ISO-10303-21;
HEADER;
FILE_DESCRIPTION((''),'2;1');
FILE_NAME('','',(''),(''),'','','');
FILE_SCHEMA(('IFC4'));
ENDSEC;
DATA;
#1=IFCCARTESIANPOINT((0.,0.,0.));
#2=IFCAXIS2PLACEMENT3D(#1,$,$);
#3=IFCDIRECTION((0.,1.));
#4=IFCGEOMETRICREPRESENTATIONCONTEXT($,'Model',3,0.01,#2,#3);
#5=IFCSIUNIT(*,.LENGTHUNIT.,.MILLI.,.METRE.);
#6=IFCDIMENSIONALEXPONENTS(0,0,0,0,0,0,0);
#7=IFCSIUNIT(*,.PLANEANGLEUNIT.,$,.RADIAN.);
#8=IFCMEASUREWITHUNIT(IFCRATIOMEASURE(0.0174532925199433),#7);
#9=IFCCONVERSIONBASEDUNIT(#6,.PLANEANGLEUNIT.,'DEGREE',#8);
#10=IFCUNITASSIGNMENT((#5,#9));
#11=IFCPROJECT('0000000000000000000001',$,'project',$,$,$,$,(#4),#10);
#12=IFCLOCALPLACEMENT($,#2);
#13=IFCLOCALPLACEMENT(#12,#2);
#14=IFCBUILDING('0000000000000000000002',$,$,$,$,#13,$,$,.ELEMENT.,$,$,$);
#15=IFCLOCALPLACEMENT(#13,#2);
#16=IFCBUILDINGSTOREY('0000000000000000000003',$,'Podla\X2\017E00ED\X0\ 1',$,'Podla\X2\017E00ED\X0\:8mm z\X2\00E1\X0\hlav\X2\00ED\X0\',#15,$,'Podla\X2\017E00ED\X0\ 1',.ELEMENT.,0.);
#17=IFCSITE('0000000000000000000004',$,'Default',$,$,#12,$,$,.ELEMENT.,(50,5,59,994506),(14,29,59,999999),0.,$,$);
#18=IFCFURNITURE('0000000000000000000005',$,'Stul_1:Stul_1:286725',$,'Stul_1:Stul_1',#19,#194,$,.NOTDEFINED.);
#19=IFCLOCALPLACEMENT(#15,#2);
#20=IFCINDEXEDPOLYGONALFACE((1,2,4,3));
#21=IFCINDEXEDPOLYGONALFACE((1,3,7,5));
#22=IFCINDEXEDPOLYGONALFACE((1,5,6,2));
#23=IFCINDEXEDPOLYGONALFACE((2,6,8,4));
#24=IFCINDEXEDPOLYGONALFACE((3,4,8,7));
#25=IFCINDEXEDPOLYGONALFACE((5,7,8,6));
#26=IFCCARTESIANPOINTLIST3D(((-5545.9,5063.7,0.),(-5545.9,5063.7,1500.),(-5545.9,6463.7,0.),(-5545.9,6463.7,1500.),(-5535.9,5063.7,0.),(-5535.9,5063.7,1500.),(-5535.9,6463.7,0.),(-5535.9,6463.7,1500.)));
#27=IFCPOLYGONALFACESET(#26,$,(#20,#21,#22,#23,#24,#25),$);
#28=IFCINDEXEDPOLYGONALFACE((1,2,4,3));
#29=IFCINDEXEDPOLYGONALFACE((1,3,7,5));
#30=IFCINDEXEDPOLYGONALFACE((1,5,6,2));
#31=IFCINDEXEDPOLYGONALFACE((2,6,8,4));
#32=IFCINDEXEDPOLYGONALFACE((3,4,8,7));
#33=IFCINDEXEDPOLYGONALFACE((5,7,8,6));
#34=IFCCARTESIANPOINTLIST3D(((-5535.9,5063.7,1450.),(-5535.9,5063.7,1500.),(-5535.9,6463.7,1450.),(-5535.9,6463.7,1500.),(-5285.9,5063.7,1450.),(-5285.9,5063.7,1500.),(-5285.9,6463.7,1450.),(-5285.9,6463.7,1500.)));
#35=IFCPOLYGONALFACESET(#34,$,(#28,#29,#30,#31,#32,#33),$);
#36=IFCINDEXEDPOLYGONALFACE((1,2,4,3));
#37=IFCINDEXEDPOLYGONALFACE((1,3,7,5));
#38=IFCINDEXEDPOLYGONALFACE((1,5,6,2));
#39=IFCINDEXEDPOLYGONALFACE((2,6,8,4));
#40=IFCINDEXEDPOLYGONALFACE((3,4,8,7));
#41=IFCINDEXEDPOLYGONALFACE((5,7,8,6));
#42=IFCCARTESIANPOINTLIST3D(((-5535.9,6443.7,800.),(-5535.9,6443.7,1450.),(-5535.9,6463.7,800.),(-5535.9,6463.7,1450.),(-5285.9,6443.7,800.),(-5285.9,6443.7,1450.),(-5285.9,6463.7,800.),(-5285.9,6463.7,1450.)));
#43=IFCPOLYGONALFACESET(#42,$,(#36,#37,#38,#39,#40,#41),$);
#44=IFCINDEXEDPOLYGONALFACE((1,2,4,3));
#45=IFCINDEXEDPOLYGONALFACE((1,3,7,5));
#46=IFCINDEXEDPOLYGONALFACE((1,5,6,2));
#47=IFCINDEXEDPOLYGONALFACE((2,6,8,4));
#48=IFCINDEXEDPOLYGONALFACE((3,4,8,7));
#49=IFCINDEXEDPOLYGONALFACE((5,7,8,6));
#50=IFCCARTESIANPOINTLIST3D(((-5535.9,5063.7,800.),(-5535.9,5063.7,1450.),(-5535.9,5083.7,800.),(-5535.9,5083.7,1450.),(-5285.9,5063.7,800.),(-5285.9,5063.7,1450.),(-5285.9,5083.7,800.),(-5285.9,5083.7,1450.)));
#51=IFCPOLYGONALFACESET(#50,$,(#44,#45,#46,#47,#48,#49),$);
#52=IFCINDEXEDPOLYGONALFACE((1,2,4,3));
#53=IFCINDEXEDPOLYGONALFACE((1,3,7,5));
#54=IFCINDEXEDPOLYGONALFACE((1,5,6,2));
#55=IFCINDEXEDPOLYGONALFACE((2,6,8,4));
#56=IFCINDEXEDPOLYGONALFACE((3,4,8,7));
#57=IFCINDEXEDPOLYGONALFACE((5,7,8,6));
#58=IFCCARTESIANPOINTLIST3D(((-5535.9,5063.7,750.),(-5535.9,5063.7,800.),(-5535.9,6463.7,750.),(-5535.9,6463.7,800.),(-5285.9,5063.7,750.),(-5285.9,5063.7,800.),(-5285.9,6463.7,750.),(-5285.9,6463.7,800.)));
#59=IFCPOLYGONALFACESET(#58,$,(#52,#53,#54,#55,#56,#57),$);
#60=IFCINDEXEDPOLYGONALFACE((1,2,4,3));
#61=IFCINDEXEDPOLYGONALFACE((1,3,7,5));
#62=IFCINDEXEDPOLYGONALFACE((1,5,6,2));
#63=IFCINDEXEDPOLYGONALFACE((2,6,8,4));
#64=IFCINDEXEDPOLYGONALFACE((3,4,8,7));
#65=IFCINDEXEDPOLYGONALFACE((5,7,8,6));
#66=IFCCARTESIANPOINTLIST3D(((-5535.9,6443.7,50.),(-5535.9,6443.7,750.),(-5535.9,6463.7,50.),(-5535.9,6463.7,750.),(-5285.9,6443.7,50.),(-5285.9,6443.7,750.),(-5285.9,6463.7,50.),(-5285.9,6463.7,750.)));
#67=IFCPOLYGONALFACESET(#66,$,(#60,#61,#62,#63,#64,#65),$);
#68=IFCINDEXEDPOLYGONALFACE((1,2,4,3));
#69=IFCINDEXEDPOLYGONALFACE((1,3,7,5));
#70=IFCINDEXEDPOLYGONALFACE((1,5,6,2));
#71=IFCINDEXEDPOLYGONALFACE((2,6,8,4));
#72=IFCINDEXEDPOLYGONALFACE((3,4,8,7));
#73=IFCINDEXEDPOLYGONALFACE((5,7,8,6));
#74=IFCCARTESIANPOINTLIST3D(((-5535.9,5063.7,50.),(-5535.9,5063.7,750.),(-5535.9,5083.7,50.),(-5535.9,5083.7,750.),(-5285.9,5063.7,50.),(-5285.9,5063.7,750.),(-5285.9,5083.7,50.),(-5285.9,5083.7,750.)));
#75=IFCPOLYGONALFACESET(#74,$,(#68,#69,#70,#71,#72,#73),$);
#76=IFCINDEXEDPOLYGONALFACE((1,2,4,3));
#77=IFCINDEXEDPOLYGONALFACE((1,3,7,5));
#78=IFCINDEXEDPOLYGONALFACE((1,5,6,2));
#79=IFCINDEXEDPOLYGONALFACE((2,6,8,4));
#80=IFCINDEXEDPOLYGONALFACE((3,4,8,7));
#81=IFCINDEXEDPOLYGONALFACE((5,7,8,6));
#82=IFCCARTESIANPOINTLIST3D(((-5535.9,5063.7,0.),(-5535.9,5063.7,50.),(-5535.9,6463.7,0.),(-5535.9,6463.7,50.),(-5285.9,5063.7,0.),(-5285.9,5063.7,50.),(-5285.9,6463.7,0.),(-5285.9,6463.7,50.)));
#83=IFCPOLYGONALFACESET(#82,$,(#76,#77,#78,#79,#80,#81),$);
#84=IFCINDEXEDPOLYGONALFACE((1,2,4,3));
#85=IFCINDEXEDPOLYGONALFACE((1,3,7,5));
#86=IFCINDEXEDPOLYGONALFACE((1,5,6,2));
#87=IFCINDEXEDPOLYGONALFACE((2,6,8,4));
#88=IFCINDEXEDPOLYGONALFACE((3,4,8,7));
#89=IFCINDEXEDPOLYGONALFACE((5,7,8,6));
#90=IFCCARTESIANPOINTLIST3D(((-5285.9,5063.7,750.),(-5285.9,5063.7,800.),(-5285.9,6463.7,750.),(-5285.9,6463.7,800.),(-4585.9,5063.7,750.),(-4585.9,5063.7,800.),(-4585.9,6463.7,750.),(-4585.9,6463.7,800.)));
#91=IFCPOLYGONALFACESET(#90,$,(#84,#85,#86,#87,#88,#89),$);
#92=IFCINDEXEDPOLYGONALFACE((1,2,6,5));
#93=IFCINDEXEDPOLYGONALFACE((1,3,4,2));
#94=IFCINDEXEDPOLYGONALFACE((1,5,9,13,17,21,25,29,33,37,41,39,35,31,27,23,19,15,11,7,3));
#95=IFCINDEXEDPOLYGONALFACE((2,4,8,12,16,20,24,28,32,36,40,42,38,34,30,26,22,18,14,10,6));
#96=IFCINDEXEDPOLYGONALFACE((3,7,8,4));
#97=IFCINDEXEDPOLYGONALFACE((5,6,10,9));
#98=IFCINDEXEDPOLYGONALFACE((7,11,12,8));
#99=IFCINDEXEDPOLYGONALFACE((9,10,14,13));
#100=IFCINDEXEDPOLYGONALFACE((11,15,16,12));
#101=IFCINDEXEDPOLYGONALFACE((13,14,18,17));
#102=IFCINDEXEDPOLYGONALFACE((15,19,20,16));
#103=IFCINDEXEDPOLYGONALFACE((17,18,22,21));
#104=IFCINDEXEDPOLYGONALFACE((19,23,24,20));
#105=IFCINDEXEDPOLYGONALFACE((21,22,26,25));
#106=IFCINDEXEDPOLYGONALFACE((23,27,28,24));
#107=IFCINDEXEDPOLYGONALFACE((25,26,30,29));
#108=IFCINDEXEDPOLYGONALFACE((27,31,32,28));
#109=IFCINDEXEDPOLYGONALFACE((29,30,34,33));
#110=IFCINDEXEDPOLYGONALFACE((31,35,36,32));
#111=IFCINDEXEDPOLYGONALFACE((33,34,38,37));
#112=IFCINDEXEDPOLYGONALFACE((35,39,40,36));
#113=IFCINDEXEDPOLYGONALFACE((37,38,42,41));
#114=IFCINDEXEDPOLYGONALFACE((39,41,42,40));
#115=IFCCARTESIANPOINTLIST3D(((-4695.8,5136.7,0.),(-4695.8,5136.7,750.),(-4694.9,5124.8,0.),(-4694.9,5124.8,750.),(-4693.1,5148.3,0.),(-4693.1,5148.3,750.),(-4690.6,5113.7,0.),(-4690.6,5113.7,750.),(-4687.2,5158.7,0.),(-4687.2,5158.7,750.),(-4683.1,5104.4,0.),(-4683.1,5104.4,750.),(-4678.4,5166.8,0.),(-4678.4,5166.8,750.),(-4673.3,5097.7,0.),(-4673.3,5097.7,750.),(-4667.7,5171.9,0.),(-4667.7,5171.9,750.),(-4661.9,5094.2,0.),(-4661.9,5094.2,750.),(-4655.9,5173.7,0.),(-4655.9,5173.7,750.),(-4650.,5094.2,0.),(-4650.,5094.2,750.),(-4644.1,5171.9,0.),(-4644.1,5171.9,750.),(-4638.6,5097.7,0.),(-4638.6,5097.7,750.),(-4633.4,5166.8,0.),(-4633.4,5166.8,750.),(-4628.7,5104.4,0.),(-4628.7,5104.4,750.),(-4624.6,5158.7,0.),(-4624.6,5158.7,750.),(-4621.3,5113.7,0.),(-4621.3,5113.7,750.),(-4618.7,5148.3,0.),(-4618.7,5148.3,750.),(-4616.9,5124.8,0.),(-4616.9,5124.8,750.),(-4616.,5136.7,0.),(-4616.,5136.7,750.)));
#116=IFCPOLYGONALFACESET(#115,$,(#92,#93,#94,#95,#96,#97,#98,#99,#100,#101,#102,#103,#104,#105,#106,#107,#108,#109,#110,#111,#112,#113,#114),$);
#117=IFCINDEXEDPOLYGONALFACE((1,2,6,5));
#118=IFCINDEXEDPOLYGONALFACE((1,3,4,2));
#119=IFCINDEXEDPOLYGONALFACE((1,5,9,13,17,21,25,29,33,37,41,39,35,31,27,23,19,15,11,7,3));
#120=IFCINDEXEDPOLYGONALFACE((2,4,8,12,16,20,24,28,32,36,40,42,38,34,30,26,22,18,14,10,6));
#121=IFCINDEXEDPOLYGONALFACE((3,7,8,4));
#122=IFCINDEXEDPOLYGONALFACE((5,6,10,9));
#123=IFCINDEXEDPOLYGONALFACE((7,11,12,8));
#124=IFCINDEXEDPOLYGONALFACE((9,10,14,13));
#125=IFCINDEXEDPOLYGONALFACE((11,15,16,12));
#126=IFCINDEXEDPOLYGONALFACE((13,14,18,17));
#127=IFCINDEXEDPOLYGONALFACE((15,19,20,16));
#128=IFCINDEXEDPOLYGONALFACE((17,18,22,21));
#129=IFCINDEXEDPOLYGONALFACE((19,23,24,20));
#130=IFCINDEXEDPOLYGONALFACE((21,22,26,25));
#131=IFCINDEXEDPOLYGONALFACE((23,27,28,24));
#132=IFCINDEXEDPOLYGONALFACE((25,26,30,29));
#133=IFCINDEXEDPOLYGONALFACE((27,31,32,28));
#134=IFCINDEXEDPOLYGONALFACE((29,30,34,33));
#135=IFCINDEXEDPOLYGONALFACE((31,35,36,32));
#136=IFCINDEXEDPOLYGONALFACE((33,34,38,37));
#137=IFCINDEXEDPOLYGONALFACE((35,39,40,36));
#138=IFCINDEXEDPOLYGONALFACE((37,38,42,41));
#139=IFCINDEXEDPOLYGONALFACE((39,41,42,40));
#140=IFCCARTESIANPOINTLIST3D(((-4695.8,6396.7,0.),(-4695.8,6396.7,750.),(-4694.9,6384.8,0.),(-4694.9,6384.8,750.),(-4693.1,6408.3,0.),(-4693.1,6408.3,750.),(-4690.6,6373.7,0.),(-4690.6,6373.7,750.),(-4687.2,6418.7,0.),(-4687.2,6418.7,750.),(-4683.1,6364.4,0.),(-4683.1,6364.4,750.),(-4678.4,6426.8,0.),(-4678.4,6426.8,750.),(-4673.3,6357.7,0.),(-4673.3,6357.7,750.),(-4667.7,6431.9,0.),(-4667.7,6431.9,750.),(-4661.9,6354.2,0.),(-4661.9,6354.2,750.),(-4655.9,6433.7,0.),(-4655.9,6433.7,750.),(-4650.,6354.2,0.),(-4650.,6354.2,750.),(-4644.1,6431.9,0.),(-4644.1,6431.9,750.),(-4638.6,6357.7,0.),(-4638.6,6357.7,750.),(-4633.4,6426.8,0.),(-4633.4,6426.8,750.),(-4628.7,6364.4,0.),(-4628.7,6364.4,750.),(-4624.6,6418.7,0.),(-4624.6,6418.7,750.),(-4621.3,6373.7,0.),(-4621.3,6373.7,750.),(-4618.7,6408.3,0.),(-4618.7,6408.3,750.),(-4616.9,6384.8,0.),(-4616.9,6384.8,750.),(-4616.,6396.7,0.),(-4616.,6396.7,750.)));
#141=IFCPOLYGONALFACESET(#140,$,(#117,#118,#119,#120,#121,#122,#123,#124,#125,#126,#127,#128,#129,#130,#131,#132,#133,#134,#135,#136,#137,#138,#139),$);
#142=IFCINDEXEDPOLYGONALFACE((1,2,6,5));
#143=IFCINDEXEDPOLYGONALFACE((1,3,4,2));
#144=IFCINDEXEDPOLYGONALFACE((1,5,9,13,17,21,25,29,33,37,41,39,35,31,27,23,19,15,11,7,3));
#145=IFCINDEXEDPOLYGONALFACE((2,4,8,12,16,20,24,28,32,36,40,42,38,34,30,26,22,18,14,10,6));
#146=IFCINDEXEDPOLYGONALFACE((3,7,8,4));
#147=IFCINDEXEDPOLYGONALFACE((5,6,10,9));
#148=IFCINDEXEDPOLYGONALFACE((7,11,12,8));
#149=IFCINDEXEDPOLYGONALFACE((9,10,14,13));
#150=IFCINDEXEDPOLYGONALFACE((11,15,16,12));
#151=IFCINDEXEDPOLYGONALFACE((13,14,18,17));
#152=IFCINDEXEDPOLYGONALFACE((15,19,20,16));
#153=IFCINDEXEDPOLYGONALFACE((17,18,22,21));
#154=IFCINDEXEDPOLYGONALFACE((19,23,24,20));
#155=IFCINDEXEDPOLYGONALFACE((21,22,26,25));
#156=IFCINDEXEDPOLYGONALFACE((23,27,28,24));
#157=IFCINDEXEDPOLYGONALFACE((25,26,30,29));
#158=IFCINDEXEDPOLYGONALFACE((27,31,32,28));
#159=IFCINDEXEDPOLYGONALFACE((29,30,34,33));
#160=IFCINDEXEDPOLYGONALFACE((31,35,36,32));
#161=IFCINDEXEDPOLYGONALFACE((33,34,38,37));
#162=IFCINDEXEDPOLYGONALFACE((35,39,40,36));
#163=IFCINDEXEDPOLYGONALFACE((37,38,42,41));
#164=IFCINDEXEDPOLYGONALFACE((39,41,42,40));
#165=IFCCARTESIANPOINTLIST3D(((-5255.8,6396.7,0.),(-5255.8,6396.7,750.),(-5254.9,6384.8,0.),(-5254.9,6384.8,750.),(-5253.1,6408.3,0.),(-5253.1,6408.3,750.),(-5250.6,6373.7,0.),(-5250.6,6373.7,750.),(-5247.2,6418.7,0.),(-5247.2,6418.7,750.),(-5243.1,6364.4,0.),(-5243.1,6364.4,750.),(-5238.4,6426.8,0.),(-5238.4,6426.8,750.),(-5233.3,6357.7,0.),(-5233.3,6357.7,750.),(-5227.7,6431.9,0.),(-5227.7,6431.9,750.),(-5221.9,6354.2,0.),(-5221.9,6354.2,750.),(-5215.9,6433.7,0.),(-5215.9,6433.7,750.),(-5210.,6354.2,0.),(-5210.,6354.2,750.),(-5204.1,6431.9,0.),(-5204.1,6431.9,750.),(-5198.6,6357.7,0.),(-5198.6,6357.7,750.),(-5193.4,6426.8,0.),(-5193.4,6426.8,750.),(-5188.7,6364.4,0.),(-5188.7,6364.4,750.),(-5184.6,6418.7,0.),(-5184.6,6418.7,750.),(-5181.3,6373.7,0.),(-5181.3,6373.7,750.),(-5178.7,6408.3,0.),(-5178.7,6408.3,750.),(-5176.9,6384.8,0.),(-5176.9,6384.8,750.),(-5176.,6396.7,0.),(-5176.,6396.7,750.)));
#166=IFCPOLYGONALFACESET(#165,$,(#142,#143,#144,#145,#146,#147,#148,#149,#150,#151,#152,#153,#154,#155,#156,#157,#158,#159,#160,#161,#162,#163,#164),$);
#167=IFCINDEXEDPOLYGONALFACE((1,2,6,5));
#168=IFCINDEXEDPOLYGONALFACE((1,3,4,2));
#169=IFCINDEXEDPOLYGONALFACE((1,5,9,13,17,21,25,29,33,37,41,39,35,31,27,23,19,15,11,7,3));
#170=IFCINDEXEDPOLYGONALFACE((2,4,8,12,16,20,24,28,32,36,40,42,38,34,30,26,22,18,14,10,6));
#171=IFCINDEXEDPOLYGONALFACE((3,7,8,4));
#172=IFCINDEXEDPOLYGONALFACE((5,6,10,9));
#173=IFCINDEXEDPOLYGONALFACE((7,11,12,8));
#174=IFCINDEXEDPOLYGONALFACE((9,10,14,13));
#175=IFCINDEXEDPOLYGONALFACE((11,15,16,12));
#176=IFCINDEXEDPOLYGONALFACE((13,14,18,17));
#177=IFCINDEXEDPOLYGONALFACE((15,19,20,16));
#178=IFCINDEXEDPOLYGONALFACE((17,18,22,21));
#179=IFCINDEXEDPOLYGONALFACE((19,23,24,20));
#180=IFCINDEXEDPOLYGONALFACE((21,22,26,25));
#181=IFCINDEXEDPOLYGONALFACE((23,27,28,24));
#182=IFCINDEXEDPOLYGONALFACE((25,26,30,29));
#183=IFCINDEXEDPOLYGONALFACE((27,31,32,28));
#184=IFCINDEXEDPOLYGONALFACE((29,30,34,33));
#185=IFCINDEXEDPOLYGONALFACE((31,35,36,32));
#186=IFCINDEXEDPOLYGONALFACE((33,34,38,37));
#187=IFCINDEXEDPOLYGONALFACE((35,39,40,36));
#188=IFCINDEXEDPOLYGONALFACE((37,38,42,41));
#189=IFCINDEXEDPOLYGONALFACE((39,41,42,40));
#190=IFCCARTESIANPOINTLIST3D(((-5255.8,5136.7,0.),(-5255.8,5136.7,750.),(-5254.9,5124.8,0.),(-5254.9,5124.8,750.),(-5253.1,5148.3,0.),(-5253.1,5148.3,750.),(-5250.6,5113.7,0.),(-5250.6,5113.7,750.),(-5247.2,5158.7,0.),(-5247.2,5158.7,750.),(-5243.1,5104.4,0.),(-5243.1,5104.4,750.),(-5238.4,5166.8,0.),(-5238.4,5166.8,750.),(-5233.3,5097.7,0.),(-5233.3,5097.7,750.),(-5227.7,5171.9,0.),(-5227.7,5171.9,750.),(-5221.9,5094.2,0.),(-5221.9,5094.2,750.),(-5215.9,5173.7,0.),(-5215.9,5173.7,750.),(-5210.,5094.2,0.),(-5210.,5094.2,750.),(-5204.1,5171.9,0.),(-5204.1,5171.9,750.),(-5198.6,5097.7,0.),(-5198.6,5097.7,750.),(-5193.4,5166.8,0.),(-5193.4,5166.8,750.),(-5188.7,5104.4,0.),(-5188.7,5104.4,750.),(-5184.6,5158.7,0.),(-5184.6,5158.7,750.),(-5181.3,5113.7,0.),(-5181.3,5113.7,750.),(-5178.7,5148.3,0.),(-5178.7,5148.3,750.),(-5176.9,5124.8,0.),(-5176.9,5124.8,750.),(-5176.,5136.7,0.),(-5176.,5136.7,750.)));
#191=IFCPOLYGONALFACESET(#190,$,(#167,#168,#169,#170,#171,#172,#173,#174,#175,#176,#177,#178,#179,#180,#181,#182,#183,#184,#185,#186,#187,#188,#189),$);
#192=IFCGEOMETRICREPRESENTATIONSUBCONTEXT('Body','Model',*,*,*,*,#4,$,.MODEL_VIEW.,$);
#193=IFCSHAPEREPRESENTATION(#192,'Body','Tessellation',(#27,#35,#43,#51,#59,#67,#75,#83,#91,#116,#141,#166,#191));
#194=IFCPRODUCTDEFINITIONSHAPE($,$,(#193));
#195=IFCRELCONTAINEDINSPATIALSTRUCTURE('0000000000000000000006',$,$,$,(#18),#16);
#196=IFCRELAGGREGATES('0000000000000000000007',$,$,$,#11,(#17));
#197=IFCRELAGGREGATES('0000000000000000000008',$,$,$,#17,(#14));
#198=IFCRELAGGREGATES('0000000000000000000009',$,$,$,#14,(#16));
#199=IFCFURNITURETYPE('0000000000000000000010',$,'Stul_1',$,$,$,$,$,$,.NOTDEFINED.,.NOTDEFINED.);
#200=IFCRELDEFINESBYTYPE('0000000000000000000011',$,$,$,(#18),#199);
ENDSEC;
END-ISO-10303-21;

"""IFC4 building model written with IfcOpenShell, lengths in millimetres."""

from ifc_helpers import new_model, entity, si_unit, converted_unit, direction, frame, frame_2d, origin, origin_2d_with_axis, place, context, subcontext, project, spatial, rectangle, circle, extrude, source, transform, mapped, type_object, type_shapes, element, save


model = new_model("IFC4")

# Units and contexts
model_context = context("Model", 3, precision=0.01, world=origin(), true_north=direction((0.0, 1.0)))
body_context = subcontext(model_context, "Body", "Model", "MODEL_VIEW")
ifc_project = project(units=[si_unit("LENGTHUNIT", "METRE", prefix="MILLI"), converted_unit("PLANEANGLEUNIT", "DEGREE", entity("IfcRatioMeasure", 0.0174532925199433), si_unit("PLANEANGLEUNIT", "RADIAN"), dimensions=[0, 0, 0, 0, 0, 0, 0])], contexts=[model_context])

# Site, building, storey
site_placement = place(None, origin())
site = spatial("IfcSite", under=ifc_project, at=site_placement, Name="Default", CompositionType="ELEMENT", RefLatitude=(50, 5, 59, 994506), RefLongitude=(14, 29, 59, 999999), RefElevation=0.0)
building_placement = place(site_placement, origin())
building = spatial("IfcBuilding", under=site, at=building_placement, CompositionType="ELEMENT")
storey_placement = place(building_placement, origin())
storey = spatial("IfcBuildingStorey", under=building, at=storey_placement, Name="Podlaží 1", ObjectType="Podlaží:8mm záhlaví", LongName="Podlaží 1", CompositionType="ELEMENT", Elevation=0.0)

# Furniture
furniture_type = type_object("IfcFurnitureType", Name="Stul_1", AssemblyPlace="NOTDEFINED", PredefinedType="NOTDEFINED")
shared_shape_1 = source(origin(), body_context, "Body", "SweptSolid", [
    extrude(rectangle(XDim=1400.0, YDim=10.0, at=origin_2d_with_axis()), frame((0.0, 605.0, 0.0), z_axis=(0.0, 0.0, 1.0), x_axis=(-1.0, 0.0, 0.0)), (0.0, 0.0, 1.0), 1500.0),
    extrude(rectangle(XDim=1400.0, YDim=250.0, at=frame_2d((0.0, 0.0), x_axis=(1.0, 0.0))), frame((0.0, 475.0, 1450.0), z_axis=(0.0, 0.0, 1.0), x_axis=(-1.0, 0.0, 0.0)), (0.0, 0.0, 1.0), 50.0),
    extrude(rectangle(XDim=20.0, YDim=250.0, at=origin_2d_with_axis()), frame((690.0, 475.0, 800.0), z_axis=(0.0, 0.0, 1.0), x_axis=(-1.0, 0.0, 0.0)), (0.0, 0.0, 1.0), 650.0),
    extrude(rectangle(XDim=20.0, YDim=250.0, at=frame_2d((0.0, 0.0), x_axis=(1.0, 0.0))), frame((-690.0, 475.0, 800.0), z_axis=(0.0, 0.0, 1.0), x_axis=(-1.0, 0.0, 0.0)), (0.0, 0.0, 1.0), 650.0),
    extrude(rectangle(XDim=1400.0, YDim=250.0, at=origin_2d_with_axis()), frame((0.0, 475.0, 750.0), z_axis=(0.0, 0.0, 1.0), x_axis=(-1.0, 0.0, 0.0)), (0.0, 0.0, 1.0), 50.0),
    extrude(rectangle(XDim=20.0, YDim=250.0, at=origin_2d_with_axis()), frame((690.0, 475.0, 50.0), z_axis=(0.0, 0.0, 1.0), x_axis=(-1.0, 0.0, 0.0)), (0.0, 0.0, 1.0), 700.0),
    extrude(rectangle(XDim=20.0, YDim=250.0, at=frame_2d((0.0, 0.0), x_axis=(1.0, 0.0))), frame((-690.0, 475.0, 50.0), z_axis=(0.0, 0.0, 1.0), x_axis=(-1.0, 0.0, 0.0)), (0.0, 0.0, 1.0), 700.0),
    extrude(rectangle(XDim=1400.0, YDim=250.0, at=origin_2d_with_axis()), frame((0.0, 475.0, 0.0), z_axis=(0.0, 0.0, 1.0), x_axis=(-1.0, 0.0, 0.0)), (0.0, 0.0, 1.0), 50.0),
    extrude(rectangle(XDim=1400.0, YDim=700.0, at=origin_2d_with_axis()), frame((0.0, 0.0, 750.0), z_axis=(0.0, 0.0, 1.0), x_axis=(-1.0, 0.0, 0.0)), (0.0, 0.0, 1.0), 50.0),
    extrude(circle(Radius=40.0, at=frame_2d((0.0, 0.0), x_axis=(1.0, 0.0))), frame((-630.0, -280.0, 0.0)), (0.0, 0.0, 1.0), 750.0),
    extrude(circle(Radius=40.0, at=frame_2d((0.0, 0.0), x_axis=(1.0, 0.0))), frame((630.0, -280.0, 0.0)), (0.0, 0.0, 1.0), 750.0),
    extrude(circle(Radius=40.0, at=frame_2d((0.0, 0.0), x_axis=(1.0, 0.0))), frame((630.0, 280.0, 0.0)), (0.0, 0.0, 1.0), 750.0),
    extrude(circle(Radius=40.0, at=frame_2d((0.0, 0.0), x_axis=(1.0, 0.0))), frame((-630.0, 280.0, 0.0)), (0.0, 0.0, 1.0), 750.0),
])
type_shapes(furniture_type, [shared_shape_1])
for number, where, z_axis, x_axis, name in (
    (1, (-4935.9, 5763.7, 0.0), (0.0, 0.0, 1.0), (0.0, 1.0, 0.0), "Stul_1:Stul_1:286725"),
):
    element("IfcFurniture", number, at=place(storey_placement, frame(where, z_axis=z_axis, x_axis=x_axis)), inside=storey, type_object=furniture_type, Name=name, ObjectType="Stul_1:Stul_1", PredefinedType="NOTDEFINED", context=body_context, shape_type="MappedRepresentation", body=[
        mapped(shared_shape_1, transform((0.0, 0.0, 0.0), scale=1.0)),
    ])

save(model, "model.ifc")
